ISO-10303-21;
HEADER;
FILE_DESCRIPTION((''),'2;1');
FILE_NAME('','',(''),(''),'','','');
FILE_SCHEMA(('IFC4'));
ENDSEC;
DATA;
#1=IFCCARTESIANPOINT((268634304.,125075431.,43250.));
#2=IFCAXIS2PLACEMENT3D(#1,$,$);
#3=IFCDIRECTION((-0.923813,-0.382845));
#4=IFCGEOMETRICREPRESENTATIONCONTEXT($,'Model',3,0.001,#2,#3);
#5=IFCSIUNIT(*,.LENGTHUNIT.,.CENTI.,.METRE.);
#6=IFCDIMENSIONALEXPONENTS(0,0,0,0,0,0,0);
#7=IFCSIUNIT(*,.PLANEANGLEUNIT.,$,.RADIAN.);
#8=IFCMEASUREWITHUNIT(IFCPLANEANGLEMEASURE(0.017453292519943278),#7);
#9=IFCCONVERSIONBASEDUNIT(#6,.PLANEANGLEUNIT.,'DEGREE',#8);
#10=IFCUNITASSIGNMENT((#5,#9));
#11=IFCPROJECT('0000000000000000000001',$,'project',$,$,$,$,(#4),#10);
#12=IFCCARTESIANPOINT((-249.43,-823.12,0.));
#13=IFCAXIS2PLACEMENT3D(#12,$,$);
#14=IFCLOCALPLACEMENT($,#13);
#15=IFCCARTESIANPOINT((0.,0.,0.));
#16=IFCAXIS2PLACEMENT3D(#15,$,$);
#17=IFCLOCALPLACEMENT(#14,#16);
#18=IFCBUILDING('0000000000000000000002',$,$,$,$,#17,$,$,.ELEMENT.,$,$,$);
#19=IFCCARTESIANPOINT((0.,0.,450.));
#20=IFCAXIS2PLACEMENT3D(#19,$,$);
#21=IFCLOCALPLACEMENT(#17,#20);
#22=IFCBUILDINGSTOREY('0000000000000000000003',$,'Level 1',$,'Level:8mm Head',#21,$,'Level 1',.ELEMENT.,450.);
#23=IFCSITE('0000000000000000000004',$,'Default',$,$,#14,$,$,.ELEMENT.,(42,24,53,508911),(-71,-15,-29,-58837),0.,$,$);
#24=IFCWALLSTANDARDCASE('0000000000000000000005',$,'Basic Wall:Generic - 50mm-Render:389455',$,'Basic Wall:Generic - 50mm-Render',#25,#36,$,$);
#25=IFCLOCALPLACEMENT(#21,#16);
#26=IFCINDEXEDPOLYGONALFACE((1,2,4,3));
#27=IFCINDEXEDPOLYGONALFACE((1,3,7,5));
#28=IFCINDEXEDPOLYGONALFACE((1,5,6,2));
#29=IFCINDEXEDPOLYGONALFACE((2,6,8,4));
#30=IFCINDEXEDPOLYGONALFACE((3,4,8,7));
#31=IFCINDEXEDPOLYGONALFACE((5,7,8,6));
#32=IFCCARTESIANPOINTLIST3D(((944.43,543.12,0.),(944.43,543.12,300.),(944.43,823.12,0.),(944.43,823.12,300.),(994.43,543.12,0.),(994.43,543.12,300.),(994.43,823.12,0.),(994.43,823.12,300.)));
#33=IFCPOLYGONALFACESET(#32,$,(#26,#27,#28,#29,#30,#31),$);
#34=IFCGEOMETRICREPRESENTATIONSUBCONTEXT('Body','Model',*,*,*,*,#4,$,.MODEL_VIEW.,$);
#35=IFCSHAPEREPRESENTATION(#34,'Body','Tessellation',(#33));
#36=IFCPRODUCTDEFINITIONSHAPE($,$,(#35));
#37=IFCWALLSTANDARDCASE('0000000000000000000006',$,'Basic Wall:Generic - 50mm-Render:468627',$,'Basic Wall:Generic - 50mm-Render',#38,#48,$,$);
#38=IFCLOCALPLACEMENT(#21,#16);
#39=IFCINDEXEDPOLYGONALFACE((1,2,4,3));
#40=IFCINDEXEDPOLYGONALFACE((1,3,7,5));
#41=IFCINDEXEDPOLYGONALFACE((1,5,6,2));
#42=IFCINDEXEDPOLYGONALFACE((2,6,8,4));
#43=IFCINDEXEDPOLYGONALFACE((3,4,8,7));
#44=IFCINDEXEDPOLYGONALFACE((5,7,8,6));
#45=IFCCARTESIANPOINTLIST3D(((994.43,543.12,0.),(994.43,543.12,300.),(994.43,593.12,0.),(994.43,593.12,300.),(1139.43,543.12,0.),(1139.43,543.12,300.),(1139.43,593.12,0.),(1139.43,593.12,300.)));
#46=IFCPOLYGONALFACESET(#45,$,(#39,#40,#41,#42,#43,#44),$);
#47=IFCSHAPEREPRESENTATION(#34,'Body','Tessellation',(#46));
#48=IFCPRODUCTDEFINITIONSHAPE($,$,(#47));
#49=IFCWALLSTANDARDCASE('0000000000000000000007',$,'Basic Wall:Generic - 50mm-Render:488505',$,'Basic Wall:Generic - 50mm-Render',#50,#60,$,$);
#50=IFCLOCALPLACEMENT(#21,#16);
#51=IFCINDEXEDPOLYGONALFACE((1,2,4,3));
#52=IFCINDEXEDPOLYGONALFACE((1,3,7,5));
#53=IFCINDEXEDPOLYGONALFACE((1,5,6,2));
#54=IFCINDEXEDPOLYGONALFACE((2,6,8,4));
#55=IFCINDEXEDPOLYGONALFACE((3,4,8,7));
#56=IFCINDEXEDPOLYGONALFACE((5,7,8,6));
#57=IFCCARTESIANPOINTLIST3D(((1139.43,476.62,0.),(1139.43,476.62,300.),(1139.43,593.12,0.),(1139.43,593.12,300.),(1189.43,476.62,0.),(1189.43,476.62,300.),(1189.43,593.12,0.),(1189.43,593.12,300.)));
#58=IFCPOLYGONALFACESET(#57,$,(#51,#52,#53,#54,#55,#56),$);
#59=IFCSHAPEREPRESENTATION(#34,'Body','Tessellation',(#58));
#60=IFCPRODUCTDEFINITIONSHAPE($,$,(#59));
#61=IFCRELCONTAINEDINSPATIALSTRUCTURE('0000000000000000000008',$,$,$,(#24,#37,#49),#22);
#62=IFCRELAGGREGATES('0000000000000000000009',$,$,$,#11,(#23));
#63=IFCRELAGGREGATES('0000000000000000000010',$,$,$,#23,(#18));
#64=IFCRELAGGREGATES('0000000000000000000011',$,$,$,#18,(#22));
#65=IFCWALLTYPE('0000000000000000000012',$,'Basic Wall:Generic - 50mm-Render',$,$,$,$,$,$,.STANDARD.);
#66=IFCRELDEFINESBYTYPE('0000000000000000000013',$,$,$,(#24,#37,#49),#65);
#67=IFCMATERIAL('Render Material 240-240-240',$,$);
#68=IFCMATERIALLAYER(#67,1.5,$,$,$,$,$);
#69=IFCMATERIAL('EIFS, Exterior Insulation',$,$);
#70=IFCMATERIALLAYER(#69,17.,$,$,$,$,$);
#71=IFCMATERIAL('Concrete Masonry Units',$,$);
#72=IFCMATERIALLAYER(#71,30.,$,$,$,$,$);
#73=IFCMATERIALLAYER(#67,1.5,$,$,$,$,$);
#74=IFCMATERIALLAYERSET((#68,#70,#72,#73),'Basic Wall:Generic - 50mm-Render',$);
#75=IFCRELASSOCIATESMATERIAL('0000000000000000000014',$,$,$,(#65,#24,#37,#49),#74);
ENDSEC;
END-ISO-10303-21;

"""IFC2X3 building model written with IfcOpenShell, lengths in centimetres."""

from ifc_helpers import new_model, entity, si_unit, converted_unit, direction, frame, frame_2d, origin, place, context, subcontext, project, spatial, rectangle, extrude, material, layer, layer_set, layer_usage, type_object, element, save


model = new_model("IFC2X3")

# Units and contexts
model_context = context("Model", 3, precision=0.001, world=frame((268634304.0, 125075431.0, 43250.0)), true_north=direction((-0.923813, -0.382845)))
body_context = subcontext(model_context, "Body", "Model", "MODEL_VIEW")
ifc_project = project(units=[si_unit("LENGTHUNIT", "METRE", prefix="CENTI"), converted_unit("PLANEANGLEUNIT", "DEGREE", entity("IfcPlaneAngleMeasure", 0.017453292519943278), si_unit("PLANEANGLEUNIT", "RADIAN"), dimensions=[0, 0, 0, 0, 0, 0, 0])], contexts=[model_context])

# Site, building, storey
site_placement = place(None, frame((-249.43, -823.12, 0.0)))
site = spatial("IfcSite", under=ifc_project, at=site_placement, Name="Default", CompositionType="ELEMENT", RefLatitude=(42, 24, 53, 508911), RefLongitude=(-71, -15, -29, -58837), RefElevation=0.0)
building_placement = place(site_placement, origin())
building = spatial("IfcBuilding", under=site, at=building_placement, CompositionType="ELEMENT")
storey_placement = place(building_placement, frame((0.0, 0.0, 450.0)))
storey = spatial("IfcBuildingStorey", under=building, at=storey_placement, Name="Level 1", ObjectType="Level:8mm Head", LongName="Level 1", CompositionType="ELEMENT", Elevation=450.0)

# Walls
ifc_material_1 = material(Name="Render Material 240-240-240")
ifc_layer_1 = layer(ifc_material_1, 1.5)
ifc_material_2 = material(Name="EIFS, Exterior Insulation")
ifc_layer_2 = layer(ifc_material_2, 17.0)
ifc_material_3 = material(Name="Concrete Masonry Units")
ifc_layer_3 = layer(ifc_material_3, 30.0)
ifc_layer_4 = layer(ifc_material_1, 1.5)
ifc_layer_set_1 = layer_set([ifc_layer_1, ifc_layer_2, ifc_layer_3, ifc_layer_4], Name="Basic Wall:Generic - 50mm-Render")
ifc_layer_usage_1 = layer_usage(ifc_layer_set_1, "AXIS2", "POSITIVE", -25.0)
wall_type = type_object("IfcWallType", Name="Basic Wall:Generic - 50mm-Render", PredefinedType="STANDARD", material=ifc_layer_set_1)
wall_1_placement = place(storey_placement, frame((969.43, 823.12, 0.0), z_axis=(0.0, 0.0, 1.0), x_axis=(0.0, -1.0, 0.0)))
element("IfcWallStandardCase", 1, at=wall_1_placement, inside=storey, type_object=wall_type, material=ifc_layer_usage_1, Name="Basic Wall:Generic - 50mm-Render:389455", ObjectType="Basic Wall:Generic - 50mm-Render", context=body_context, shape_type="SweptSolid", body=[
    extrude(rectangle(XDim=280.0, YDim=50.0, at=frame_2d((140.0, 0.0), x_axis=(-1.0, 0.0))), origin(), (0.0, 0.0, 1.0), 300.0),
])
ifc_layer_usage_2 = layer_usage(ifc_layer_set_1, "AXIS2", "NEGATIVE", 25.0)
wall_2_placement = place(storey_placement, frame((1139.43, 568.12, 0.0), z_axis=(0.0, 0.0, 1.0), x_axis=(-1.0, 0.0, 0.0)))
element("IfcWallStandardCase", 2, at=wall_2_placement, inside=storey, type_object=wall_type, material=ifc_layer_usage_2, Name="Basic Wall:Generic - 50mm-Render:468627", ObjectType="Basic Wall:Generic - 50mm-Render", context=body_context, shape_type="SweptSolid", body=[
    extrude(rectangle(XDim=145.0, YDim=50.0, at=frame_2d((72.5, 0.0), x_axis=(-1.0, 0.0))), origin(), (0.0, 0.0, 1.0), 300.0),
])
ifc_layer_usage_3 = layer_usage(ifc_layer_set_1, "AXIS2", "POSITIVE", -25.0)
wall_3_placement = place(storey_placement, frame((1164.43, 593.12, 0.0), z_axis=(0.0, 0.0, 1.0), x_axis=(0.0, -1.0, 0.0)))
element("IfcWallStandardCase", 3, at=wall_3_placement, inside=storey, type_object=wall_type, material=ifc_layer_usage_3, Name="Basic Wall:Generic - 50mm-Render:488505", ObjectType="Basic Wall:Generic - 50mm-Render", context=body_context, shape_type="SweptSolid", body=[
    extrude(rectangle(XDim=116.5, YDim=50.0, at=frame_2d((58.25, 0.0), x_axis=(-1.0, 0.0))), origin(), (0.0, 0.0, 1.0), 300.0),
])

save(model, "model.ifc")
